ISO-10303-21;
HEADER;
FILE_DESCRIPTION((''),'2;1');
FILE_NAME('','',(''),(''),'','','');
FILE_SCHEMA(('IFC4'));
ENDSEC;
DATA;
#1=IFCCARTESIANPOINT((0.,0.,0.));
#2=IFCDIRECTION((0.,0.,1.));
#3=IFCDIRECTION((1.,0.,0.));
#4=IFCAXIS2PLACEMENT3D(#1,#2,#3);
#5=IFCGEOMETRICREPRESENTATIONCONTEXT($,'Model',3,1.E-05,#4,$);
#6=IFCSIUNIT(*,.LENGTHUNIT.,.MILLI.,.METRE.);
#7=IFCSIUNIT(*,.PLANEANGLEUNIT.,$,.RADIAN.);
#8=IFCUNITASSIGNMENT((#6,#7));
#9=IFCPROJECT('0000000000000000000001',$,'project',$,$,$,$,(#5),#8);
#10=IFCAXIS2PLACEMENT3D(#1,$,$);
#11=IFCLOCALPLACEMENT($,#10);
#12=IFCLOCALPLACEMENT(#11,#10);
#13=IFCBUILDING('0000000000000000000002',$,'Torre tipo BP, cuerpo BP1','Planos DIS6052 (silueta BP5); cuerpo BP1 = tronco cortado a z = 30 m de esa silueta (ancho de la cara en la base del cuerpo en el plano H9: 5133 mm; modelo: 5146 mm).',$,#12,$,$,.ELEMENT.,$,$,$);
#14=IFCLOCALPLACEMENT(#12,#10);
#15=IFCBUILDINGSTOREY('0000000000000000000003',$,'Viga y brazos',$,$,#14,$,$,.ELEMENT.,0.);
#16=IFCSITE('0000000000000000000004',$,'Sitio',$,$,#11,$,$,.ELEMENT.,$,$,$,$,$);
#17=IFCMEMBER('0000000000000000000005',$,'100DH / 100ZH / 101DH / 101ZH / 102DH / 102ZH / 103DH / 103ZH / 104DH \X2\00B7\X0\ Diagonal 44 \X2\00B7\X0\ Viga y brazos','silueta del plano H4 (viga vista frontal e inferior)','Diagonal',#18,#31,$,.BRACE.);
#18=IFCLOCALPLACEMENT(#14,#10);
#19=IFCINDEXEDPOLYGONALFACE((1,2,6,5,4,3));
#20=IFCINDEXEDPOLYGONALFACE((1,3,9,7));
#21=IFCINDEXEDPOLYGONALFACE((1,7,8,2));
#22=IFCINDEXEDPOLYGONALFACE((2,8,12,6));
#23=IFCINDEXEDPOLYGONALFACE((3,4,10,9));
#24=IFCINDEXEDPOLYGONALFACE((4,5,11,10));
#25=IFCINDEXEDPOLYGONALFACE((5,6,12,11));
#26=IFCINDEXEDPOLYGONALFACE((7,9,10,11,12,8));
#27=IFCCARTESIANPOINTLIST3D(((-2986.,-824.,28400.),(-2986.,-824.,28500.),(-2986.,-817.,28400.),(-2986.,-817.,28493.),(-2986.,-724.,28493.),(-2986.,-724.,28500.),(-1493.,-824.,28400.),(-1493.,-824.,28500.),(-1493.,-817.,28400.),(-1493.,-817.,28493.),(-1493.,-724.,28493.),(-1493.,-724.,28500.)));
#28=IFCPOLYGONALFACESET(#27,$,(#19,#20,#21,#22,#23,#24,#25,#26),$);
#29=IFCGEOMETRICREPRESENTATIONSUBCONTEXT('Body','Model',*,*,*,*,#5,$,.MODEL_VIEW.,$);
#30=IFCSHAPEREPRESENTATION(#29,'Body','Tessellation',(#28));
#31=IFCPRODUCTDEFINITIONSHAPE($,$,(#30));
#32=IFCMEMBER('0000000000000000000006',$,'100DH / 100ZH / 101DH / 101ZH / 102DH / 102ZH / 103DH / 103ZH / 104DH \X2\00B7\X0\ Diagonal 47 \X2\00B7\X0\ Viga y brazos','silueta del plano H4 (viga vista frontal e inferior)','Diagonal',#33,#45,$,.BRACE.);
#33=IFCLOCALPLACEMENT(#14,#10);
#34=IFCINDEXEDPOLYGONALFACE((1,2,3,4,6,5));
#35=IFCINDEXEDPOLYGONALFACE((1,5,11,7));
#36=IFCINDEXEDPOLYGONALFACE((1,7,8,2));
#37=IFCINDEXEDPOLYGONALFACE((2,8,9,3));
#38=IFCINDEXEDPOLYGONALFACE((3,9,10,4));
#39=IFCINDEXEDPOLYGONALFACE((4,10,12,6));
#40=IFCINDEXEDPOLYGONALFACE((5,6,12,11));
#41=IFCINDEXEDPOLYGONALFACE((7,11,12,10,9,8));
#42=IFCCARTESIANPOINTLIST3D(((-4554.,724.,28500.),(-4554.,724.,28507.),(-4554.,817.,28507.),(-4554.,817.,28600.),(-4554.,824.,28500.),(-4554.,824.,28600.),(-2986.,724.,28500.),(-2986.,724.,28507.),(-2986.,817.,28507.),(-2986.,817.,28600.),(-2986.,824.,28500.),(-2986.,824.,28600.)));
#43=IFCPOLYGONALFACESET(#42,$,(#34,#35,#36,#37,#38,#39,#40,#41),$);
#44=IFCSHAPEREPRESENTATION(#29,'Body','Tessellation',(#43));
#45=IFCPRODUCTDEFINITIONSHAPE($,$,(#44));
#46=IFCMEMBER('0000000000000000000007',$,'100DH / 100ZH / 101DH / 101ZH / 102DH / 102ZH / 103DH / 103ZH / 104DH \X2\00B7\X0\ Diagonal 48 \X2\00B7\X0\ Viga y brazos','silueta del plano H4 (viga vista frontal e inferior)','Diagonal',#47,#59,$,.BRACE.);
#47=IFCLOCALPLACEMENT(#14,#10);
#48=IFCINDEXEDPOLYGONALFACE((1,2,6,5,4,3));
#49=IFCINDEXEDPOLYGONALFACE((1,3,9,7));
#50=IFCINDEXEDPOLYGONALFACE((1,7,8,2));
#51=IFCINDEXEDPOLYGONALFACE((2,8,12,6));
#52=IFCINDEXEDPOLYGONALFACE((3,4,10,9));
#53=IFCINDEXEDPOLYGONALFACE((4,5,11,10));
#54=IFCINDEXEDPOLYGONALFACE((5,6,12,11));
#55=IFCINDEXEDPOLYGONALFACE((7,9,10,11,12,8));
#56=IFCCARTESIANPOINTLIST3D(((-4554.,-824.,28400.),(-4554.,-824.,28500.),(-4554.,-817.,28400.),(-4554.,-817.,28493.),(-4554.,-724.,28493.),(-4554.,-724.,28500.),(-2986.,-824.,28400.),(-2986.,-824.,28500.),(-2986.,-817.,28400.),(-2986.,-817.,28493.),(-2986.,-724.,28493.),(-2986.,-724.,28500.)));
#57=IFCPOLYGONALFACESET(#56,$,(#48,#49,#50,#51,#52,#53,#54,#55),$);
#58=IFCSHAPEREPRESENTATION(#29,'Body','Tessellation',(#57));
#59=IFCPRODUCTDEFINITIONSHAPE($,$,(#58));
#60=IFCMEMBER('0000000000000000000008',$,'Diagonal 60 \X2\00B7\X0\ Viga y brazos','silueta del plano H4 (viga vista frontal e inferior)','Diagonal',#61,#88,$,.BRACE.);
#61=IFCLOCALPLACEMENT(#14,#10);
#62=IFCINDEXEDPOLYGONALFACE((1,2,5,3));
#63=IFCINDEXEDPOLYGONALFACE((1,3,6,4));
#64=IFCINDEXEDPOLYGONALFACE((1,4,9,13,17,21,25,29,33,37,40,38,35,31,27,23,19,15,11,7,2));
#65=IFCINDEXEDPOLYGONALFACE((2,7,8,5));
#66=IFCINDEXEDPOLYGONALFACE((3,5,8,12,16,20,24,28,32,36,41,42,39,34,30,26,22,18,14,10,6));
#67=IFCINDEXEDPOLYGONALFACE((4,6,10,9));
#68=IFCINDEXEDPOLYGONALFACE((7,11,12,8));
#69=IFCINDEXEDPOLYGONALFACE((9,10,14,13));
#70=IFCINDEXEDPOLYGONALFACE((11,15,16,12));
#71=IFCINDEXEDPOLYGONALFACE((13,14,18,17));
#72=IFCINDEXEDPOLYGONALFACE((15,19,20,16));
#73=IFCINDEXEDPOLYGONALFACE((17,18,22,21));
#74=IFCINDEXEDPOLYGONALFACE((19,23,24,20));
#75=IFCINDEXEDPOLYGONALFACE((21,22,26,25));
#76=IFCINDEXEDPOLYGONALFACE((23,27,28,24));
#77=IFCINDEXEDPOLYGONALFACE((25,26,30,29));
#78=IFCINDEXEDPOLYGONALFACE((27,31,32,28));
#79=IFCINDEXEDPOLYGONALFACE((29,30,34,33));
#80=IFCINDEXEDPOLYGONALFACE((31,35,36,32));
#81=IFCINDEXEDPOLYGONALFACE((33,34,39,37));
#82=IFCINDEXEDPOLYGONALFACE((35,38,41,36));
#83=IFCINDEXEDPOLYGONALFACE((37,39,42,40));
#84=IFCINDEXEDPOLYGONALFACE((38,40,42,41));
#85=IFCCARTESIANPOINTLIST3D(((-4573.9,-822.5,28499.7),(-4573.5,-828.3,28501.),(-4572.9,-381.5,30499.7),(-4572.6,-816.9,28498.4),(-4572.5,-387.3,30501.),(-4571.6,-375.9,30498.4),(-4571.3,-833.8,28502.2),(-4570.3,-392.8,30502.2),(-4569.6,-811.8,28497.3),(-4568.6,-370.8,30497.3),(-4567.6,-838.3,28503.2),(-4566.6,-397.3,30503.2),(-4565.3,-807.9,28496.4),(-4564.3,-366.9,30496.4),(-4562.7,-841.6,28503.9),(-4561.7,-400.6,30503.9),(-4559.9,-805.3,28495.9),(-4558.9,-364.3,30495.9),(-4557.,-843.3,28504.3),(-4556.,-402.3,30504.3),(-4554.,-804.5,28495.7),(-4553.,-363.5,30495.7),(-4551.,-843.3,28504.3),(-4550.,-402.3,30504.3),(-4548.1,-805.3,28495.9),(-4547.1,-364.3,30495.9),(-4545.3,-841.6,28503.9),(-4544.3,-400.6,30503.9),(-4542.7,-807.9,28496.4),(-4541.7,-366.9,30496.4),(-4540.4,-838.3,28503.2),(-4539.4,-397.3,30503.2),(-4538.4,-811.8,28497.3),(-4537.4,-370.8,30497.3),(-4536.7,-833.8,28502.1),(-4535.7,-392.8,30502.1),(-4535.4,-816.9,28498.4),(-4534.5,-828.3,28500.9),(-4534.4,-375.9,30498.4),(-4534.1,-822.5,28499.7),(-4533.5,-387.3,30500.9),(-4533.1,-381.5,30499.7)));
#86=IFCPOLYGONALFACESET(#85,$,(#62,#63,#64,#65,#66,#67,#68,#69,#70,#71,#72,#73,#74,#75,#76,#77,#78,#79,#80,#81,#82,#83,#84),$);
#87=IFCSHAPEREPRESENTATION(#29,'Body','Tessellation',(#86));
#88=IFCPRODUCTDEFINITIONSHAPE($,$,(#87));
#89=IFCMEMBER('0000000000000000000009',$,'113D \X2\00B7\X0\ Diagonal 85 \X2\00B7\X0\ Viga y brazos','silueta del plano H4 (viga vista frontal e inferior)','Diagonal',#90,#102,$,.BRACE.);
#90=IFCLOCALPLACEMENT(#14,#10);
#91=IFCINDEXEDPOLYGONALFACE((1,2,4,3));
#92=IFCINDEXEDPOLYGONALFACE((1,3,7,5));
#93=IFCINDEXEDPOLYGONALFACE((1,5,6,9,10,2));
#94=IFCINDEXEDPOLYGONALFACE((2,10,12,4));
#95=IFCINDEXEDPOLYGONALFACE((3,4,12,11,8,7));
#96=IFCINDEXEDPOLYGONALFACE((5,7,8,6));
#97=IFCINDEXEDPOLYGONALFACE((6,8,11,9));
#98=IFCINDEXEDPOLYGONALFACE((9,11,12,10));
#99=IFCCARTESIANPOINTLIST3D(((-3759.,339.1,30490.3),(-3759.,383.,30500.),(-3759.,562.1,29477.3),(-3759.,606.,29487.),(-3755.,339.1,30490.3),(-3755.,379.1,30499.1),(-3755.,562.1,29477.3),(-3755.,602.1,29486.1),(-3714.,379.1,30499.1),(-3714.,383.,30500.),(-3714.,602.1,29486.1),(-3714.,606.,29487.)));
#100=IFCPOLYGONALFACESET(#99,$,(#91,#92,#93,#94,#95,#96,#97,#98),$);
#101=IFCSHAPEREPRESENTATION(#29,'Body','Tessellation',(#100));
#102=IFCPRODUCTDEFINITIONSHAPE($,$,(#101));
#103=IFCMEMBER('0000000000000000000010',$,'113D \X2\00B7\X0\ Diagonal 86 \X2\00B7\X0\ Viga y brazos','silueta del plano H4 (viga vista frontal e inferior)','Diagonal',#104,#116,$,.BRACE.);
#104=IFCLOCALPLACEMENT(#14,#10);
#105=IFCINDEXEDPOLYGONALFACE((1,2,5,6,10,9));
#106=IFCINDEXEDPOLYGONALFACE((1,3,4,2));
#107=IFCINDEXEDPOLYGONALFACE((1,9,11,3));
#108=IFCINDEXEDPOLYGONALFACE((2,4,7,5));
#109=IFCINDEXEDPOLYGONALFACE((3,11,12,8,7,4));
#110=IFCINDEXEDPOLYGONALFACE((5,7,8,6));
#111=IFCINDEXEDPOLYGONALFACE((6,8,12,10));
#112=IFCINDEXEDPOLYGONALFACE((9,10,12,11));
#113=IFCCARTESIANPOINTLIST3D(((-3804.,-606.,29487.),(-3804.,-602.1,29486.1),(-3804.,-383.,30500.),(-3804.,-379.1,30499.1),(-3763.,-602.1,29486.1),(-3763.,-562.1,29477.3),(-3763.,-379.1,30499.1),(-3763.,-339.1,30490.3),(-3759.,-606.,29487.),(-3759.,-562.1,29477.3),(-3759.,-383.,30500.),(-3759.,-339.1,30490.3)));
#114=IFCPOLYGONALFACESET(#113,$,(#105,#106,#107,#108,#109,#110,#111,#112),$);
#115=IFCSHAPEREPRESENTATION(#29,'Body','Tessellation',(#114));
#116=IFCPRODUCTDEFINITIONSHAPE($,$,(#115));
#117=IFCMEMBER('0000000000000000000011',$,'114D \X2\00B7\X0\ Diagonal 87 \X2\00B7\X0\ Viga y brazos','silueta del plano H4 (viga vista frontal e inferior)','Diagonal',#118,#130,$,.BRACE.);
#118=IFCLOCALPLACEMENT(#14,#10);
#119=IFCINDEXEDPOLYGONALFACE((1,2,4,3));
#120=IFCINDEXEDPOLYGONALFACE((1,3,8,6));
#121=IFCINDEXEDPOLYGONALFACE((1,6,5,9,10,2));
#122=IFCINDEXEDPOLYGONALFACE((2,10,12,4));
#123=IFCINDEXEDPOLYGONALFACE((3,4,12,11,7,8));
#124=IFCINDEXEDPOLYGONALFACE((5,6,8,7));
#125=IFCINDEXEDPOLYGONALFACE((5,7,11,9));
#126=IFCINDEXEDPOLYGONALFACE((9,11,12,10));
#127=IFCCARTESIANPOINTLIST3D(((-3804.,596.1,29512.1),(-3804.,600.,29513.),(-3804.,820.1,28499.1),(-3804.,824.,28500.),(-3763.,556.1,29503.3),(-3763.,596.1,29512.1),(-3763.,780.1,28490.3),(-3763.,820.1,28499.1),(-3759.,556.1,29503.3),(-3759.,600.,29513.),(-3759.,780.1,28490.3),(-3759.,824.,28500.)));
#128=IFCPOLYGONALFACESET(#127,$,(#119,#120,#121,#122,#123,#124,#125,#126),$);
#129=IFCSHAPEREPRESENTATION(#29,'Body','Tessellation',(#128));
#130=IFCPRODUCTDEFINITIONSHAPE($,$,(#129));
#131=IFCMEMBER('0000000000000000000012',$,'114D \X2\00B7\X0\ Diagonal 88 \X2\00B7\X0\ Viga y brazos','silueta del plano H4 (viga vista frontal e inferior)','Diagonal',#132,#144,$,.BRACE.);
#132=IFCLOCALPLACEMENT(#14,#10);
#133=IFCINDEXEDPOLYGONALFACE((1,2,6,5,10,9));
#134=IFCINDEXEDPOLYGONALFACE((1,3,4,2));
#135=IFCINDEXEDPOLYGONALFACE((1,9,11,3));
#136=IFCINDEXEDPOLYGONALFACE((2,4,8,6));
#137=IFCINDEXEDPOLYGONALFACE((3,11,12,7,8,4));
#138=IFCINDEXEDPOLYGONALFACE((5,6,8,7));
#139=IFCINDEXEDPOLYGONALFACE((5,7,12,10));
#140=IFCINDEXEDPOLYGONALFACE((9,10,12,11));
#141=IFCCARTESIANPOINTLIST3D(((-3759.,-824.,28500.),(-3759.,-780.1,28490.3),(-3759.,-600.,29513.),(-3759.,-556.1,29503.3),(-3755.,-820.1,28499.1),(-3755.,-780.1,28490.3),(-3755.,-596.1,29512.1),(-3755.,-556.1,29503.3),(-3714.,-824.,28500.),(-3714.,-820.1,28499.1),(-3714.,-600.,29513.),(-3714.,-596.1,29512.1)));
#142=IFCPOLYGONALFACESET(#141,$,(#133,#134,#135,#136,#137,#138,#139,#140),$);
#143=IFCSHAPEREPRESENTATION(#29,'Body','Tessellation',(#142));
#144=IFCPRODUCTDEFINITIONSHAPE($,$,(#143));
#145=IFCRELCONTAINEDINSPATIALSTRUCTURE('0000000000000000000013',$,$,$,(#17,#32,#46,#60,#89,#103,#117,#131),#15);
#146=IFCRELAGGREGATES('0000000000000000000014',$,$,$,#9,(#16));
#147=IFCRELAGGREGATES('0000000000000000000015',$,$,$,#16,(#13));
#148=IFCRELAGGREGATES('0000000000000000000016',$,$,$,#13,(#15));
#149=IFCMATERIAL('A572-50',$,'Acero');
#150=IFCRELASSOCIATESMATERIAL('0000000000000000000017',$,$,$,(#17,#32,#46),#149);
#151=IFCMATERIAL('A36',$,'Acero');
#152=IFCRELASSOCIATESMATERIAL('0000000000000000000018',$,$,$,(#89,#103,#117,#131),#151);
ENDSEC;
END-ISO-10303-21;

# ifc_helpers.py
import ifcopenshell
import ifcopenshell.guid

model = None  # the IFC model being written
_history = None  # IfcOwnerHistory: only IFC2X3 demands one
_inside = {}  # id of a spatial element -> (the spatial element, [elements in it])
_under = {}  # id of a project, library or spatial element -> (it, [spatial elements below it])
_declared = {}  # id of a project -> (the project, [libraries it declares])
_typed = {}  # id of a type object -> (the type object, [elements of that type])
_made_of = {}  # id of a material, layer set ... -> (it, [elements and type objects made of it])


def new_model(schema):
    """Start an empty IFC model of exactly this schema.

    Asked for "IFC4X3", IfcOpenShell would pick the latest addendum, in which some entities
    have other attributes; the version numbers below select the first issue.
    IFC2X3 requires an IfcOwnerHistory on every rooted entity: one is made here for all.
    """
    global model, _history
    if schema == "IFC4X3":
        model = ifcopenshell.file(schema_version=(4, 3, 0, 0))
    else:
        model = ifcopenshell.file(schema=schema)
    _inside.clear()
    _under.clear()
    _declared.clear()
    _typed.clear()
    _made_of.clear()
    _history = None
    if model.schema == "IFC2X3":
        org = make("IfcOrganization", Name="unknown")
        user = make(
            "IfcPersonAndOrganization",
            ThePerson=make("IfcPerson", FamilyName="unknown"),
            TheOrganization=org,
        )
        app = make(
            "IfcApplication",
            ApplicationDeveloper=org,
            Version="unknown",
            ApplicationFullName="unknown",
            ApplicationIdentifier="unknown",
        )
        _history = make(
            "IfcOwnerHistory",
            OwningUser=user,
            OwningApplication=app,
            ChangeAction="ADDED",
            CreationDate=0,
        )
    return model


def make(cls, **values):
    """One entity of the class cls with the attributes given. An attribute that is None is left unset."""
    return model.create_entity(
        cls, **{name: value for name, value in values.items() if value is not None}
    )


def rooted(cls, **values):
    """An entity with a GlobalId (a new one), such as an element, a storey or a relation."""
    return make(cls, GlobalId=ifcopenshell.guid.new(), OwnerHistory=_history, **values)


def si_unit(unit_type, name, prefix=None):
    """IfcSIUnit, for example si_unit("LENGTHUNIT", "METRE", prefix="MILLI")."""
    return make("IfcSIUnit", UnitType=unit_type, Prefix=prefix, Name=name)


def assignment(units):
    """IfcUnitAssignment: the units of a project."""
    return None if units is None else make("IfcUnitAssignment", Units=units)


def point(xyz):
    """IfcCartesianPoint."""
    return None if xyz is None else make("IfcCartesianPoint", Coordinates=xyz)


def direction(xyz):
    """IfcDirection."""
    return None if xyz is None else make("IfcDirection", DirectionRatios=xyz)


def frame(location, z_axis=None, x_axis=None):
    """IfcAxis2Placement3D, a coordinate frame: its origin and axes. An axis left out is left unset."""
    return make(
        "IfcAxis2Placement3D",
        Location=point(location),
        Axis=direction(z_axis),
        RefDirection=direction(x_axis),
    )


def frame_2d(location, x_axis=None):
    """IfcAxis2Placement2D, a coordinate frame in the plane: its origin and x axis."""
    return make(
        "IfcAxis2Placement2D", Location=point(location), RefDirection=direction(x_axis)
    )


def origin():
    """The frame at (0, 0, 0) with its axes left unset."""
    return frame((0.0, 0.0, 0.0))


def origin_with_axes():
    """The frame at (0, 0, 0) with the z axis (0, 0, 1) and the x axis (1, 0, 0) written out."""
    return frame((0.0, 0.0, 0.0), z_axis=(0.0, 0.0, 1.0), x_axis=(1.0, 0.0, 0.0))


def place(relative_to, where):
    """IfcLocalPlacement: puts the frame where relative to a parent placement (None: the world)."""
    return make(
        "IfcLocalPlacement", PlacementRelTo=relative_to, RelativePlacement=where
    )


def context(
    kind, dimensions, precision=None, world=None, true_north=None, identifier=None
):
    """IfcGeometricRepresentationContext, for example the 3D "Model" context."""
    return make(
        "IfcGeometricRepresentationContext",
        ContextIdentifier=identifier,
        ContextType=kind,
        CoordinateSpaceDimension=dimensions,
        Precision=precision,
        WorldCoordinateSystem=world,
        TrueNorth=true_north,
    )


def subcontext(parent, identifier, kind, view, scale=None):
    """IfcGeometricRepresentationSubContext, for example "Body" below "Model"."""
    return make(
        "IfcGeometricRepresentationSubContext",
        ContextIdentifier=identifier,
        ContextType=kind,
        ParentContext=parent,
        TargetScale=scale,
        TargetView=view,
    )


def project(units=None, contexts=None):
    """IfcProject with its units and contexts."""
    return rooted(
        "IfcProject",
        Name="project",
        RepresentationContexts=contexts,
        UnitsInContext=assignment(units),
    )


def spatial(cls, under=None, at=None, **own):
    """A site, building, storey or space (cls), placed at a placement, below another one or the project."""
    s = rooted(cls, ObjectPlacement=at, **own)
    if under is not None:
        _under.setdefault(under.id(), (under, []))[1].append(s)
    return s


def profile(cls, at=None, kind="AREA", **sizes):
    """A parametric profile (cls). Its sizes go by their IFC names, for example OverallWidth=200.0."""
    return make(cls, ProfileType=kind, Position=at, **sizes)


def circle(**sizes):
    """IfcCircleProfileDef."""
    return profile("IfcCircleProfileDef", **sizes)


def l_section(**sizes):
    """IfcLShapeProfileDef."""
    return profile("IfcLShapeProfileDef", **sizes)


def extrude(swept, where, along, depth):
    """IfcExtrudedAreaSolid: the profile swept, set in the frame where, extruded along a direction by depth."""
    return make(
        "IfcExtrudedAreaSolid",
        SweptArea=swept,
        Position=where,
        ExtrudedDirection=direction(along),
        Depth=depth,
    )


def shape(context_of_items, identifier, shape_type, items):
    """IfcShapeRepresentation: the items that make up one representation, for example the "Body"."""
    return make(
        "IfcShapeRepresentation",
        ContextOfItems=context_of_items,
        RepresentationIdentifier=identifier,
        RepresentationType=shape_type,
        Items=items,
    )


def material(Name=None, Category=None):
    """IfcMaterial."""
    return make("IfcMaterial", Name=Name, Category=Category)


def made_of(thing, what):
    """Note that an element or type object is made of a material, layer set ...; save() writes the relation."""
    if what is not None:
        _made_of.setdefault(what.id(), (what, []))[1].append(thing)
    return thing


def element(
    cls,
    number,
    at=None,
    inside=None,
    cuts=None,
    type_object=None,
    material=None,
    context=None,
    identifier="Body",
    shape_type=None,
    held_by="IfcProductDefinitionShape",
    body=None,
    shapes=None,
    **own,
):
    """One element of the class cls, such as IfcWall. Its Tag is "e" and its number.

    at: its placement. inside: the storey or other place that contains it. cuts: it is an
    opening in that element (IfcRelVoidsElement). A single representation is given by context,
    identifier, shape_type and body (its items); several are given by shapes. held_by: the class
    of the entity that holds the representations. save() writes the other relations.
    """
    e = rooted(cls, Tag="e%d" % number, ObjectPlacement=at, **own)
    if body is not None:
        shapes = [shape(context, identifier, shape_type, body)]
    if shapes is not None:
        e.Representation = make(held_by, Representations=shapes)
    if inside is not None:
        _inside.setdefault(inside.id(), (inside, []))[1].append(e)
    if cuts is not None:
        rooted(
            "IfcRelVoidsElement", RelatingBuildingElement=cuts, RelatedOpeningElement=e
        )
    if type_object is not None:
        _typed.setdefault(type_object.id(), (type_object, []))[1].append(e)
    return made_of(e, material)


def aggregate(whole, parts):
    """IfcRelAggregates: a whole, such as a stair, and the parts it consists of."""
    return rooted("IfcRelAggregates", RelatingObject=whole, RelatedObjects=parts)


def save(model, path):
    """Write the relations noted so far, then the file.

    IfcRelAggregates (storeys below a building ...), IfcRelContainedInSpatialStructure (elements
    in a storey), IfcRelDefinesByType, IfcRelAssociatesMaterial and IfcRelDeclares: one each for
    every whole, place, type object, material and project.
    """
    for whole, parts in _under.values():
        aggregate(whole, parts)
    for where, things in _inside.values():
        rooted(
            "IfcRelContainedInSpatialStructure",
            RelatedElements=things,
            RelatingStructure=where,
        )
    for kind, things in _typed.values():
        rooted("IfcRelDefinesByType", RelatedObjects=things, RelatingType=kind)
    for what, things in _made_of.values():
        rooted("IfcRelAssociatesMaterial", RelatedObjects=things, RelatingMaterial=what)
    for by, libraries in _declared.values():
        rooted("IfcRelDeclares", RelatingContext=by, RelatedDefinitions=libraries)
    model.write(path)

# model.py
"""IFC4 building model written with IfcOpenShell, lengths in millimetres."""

from ifc_helpers import new_model, si_unit, frame, frame_2d, origin, origin_with_axes, place, context, subcontext, project, spatial, circle, l_section, extrude, material, element, save


model = new_model("IFC4")

# Units and contexts
model_context = context("Model", 3, precision=1e-05, world=origin_with_axes())
body_context = subcontext(model_context, "Body", "Model", "MODEL_VIEW")
ifc_project = project(units=[si_unit("LENGTHUNIT", "METRE", prefix="MILLI"), si_unit("PLANEANGLEUNIT", "RADIAN")], contexts=[model_context])

# Site, building, storey
site_placement = place(None, origin())
site = spatial("IfcSite", under=ifc_project, at=site_placement, Name="Sitio", CompositionType="ELEMENT")
building_placement = place(site_placement, origin())
building = spatial("IfcBuilding", under=site, at=building_placement, Name="Torre tipo BP, cuerpo BP1", Description="Planos DIS6052 (silueta BP5); cuerpo BP1 = tronco cortado a z = 30 m de esa silueta (ancho de la cara en la base del cuerpo en el plano H9: 5133 mm; modelo: 5146 mm).", CompositionType="ELEMENT")
storey_placement = place(building_placement, origin())
storey = spatial("IfcBuildingStorey", under=building, at=storey_placement, Name="Viga y brazos", CompositionType="ELEMENT", Elevation=0.0)

# Members
ifc_material_1 = material(Name="A572-50", Category="Acero")
for number, where, z_axis, x_axis, name in (
    (1, (-1493.0, -824.0, 28500.0), (-1.0, 0.0, 0.0), (0.0, 1.0, 0.0), "100DH / 100ZH / 101DH / 101ZH / 102DH / 102ZH / 103DH / 103ZH / 104DH · Diagonal 44 · Viga y brazos"),
):
    element("IfcMember", number, at=place(storey_placement, frame(where, z_axis=z_axis, x_axis=x_axis)), inside=storey, material=ifc_material_1, Name=name, Description="silueta del plano H4 (viga vista frontal e inferior)", ObjectType="Diagonal", PredefinedType="BRACE", context=body_context, shape_type="SweptSolid", body=[
        extrude(l_section(Depth=100.0, Width=100.0, Thickness=7.0, at=frame_2d((50.0, 50.0))), None, (0.0, 0.0, 1.0), 1493.0),
    ])
for number, where, z_axis, x_axis, name in (
    (2, (-2986.0, 824.0, 28500.0), (-1.0, 0.0, 0.0), (0.0, -1.0, 0.0), "100DH / 100ZH / 101DH / 101ZH / 102DH / 102ZH / 103DH / 103ZH / 104DH · Diagonal 47 · Viga y brazos"),
    (3, (-2986.0, -824.0, 28500.0), (-1.0, 0.0, 0.0), (0.0, 1.0, 0.0), "100DH / 100ZH / 101DH / 101ZH / 102DH / 102ZH / 103DH / 103ZH / 104DH · Diagonal 48 · Viga y brazos"),
):
    element("IfcMember", number, at=place(storey_placement, frame(where, z_axis=z_axis, x_axis=x_axis)), inside=storey, material=ifc_material_1, Name=name, Description="silueta del plano H4 (viga vista frontal e inferior)", ObjectType="Diagonal", PredefinedType="BRACE", context=body_context, shape_type="SweptSolid", body=[
        extrude(l_section(Depth=100.0, Width=100.0, Thickness=7.0, at=frame_2d((50.0, 50.0))), None, (0.0, 0.0, 1.0), 1568.0),
    ])
member_placement = place(storey_placement, frame((-4553.0, -383.0, 30500.0), z_axis=(-0.000488, -0.215327, -0.976542), x_axis=(-0.000108, 0.976542, -0.215327)))
element("IfcMember", 4, at=member_placement, inside=storey, Name="Diagonal 60 · Viga y brazos", Description="silueta del plano H4 (viga vista frontal e inferior)", ObjectType="Diagonal", PredefinedType="BRACE", context=body_context, shape_type="SweptSolid", body=[
    extrude(circle(Radius=20.0), None, (0.0, 0.0, 1.0), 2048.0),
])
ifc_material_2 = material(Name="A36", Category="Acero")
for number, where, z_axis, x_axis, name in (
    (5, (-3759.0, 606.0, 29487.0), (0.0, -0.214991, 0.976616), (0.0, -0.976616, -0.214991), "113D · Diagonal 85 · Viga y brazos"),
    (6, (-3759.0, -606.0, 29487.0), (0.0, 0.214991, 0.976616), (0.0, 0.976616, -0.214991), "113D · Diagonal 86 · Viga y brazos"),
):
    element("IfcMember", number, at=place(storey_placement, frame(where, z_axis=z_axis, x_axis=x_axis)), inside=storey, material=ifc_material_2, Name=name, Description="silueta del plano H4 (viga vista frontal e inferior)", ObjectType="Diagonal", PredefinedType="BRACE", context=body_context, shape_type="SweptSolid", body=[
        extrude(l_section(Depth=45.0, Width=45.0, Thickness=4.0, at=frame_2d((22.5, 22.5))), None, (0.0, 0.0, 1.0), 1037.3),
    ])
for number, where, z_axis, x_axis, name in (
    (7, (-3759.0, 600.0, 29513.0), (0.0, 0.21591, -0.976413), (0.0, -0.976413, -0.21591), "114D · Diagonal 87 · Viga y brazos"),
    (8, (-3759.0, -600.0, 29513.0), (0.0, -0.21591, -0.976413), (0.0, 0.976413, -0.21591), "114D · Diagonal 88 · Viga y brazos"),
):
    element("IfcMember", number, at=place(storey_placement, frame(where, z_axis=z_axis, x_axis=x_axis)), inside=storey, material=ifc_material_2, Name=name, Description="silueta del plano H4 (viga vista frontal e inferior)", ObjectType="Diagonal", PredefinedType="BRACE", context=body_context, shape_type="SweptSolid", body=[
        extrude(l_section(Depth=45.0, Width=45.0, Thickness=4.0, at=frame_2d((22.5, 22.5))), None, (0.0, 0.0, 1.0), 1037.5),
    ])

save(model, "model.ifc")
